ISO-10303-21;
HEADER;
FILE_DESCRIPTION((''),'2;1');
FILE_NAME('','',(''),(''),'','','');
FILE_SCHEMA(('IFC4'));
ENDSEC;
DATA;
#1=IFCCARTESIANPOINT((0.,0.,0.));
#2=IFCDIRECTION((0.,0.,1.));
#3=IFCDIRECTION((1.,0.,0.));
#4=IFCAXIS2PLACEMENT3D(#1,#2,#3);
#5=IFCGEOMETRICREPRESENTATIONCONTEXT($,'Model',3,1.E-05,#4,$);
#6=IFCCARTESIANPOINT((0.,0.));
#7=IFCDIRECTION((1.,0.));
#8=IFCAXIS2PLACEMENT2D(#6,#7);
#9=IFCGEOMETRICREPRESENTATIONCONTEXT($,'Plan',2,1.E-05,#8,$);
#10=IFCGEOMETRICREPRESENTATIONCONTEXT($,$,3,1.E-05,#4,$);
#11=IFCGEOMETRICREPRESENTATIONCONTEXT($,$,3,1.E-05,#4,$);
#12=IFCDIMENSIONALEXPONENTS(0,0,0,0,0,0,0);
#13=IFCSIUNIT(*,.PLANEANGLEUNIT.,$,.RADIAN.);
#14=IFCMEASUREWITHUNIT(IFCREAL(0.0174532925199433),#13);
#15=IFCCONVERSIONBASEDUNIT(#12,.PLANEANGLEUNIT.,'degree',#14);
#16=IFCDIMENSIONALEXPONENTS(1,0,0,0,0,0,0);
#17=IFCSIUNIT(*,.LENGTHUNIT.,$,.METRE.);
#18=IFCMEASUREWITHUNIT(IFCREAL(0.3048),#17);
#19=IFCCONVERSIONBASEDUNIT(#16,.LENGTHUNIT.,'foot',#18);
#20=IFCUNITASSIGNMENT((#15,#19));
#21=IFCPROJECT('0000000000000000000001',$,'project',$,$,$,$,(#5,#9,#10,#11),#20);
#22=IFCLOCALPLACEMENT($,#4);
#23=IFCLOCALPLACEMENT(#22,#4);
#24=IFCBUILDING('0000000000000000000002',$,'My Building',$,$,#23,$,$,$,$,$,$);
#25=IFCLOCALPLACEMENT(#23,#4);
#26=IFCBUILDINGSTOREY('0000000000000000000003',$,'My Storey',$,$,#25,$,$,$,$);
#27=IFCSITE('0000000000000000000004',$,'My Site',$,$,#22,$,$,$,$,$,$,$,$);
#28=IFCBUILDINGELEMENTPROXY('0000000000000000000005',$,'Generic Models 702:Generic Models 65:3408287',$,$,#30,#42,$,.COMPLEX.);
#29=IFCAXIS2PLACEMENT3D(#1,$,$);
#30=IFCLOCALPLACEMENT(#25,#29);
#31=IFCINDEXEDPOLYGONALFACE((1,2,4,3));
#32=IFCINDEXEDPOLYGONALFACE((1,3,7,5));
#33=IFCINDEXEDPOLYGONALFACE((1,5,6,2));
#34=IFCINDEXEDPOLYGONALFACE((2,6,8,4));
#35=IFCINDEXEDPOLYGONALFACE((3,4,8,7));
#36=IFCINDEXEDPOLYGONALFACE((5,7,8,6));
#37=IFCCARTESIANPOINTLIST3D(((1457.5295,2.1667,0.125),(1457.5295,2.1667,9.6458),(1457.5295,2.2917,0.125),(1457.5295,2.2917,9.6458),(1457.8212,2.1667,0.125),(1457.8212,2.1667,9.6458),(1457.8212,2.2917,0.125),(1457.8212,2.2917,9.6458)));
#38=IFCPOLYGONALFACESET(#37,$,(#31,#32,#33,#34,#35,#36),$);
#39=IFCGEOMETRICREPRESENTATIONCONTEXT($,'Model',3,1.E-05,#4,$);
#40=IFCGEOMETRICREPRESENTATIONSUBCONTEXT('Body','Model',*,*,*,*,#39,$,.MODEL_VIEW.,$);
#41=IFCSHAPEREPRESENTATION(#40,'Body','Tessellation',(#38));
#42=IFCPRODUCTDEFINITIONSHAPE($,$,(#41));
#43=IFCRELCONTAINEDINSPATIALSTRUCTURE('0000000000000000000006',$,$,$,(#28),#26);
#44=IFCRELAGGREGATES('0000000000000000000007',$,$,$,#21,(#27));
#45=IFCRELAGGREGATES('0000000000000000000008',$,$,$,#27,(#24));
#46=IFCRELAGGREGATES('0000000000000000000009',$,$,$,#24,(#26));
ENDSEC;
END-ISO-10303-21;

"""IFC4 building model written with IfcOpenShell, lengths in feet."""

from ifc_helpers import new_model, entity, si_unit, converted_unit, frame, origin_with_axes, origin_2d_with_axis, place, context, subcontext, project, spatial, polyline, outline, extrude, element, save


model = new_model("IFC4")

# Units and contexts
model_context_1 = context("Model", 3, precision=1e-05, world=origin_with_axes())
plan_context = context("Plan", 2, precision=1e-05, world=origin_2d_with_axis())
model_context_2 = context("Model", 3, precision=1e-05, world=origin_with_axes())
context_of_model_1 = context(None, 3, precision=1e-05, world=origin_with_axes())
context_of_model_2 = context(None, 3, precision=1e-05, world=origin_with_axes())
body_context_1 = subcontext(model_context_2, "Body", "Model", "MODEL_VIEW")
ifc_project = project(units=[converted_unit("PLANEANGLEUNIT", "degree", entity("IfcReal", 0.0174532925199433), si_unit("PLANEANGLEUNIT", "RADIAN"), dimensions=[0, 0, 0, 0, 0, 0, 0]), converted_unit("LENGTHUNIT", "foot", entity("IfcReal", 0.3048), si_unit("LENGTHUNIT", "METRE"), dimensions=[1, 0, 0, 0, 0, 0, 0])], contexts=[model_context_1, plan_context, context_of_model_1, context_of_model_2])

# Site, building, storey
site_placement = place(None, origin_with_axes())
site = spatial("IfcSite", under=ifc_project, at=site_placement, Name="My Site")
building_placement = place(site_placement, origin_with_axes())
building = spatial("IfcBuilding", under=site, at=building_placement, Name="My Building")
storey_placement = place(building_placement, origin_with_axes())
storey = spatial("IfcBuildingStorey", under=building, at=storey_placement, Name="My Storey")

# Building element proxy
proxy_placement = place(storey_placement, frame((1457.5295, 2.1667, 0.125), z_axis=(0.0, 0.0, 1.0), x_axis=(1.0, 0.0, 0.0)))
element("IfcBuildingElementProxy", 1, at=proxy_placement, inside=storey, Name="Generic Models 702:Generic Models 65:3408287", PredefinedType="COMPLEX", context=body_context_1, shape_type="SweptSolid", body=[
    extrude(outline(polyline([(-0.1458, -0.0625), (0.1458, -0.0625), (0.1458, 0.0625), (-0.1458, 0.0625), (-0.1458, -0.0625)])), frame((0.1458, 0.0625, 0.0), z_axis=(0.0, 0.0, -1.0), x_axis=(-1.0, 0.0, 0.0)), (0.0, 0.0, -1.0), 9.5208),
])

save(model, "model.ifc")
